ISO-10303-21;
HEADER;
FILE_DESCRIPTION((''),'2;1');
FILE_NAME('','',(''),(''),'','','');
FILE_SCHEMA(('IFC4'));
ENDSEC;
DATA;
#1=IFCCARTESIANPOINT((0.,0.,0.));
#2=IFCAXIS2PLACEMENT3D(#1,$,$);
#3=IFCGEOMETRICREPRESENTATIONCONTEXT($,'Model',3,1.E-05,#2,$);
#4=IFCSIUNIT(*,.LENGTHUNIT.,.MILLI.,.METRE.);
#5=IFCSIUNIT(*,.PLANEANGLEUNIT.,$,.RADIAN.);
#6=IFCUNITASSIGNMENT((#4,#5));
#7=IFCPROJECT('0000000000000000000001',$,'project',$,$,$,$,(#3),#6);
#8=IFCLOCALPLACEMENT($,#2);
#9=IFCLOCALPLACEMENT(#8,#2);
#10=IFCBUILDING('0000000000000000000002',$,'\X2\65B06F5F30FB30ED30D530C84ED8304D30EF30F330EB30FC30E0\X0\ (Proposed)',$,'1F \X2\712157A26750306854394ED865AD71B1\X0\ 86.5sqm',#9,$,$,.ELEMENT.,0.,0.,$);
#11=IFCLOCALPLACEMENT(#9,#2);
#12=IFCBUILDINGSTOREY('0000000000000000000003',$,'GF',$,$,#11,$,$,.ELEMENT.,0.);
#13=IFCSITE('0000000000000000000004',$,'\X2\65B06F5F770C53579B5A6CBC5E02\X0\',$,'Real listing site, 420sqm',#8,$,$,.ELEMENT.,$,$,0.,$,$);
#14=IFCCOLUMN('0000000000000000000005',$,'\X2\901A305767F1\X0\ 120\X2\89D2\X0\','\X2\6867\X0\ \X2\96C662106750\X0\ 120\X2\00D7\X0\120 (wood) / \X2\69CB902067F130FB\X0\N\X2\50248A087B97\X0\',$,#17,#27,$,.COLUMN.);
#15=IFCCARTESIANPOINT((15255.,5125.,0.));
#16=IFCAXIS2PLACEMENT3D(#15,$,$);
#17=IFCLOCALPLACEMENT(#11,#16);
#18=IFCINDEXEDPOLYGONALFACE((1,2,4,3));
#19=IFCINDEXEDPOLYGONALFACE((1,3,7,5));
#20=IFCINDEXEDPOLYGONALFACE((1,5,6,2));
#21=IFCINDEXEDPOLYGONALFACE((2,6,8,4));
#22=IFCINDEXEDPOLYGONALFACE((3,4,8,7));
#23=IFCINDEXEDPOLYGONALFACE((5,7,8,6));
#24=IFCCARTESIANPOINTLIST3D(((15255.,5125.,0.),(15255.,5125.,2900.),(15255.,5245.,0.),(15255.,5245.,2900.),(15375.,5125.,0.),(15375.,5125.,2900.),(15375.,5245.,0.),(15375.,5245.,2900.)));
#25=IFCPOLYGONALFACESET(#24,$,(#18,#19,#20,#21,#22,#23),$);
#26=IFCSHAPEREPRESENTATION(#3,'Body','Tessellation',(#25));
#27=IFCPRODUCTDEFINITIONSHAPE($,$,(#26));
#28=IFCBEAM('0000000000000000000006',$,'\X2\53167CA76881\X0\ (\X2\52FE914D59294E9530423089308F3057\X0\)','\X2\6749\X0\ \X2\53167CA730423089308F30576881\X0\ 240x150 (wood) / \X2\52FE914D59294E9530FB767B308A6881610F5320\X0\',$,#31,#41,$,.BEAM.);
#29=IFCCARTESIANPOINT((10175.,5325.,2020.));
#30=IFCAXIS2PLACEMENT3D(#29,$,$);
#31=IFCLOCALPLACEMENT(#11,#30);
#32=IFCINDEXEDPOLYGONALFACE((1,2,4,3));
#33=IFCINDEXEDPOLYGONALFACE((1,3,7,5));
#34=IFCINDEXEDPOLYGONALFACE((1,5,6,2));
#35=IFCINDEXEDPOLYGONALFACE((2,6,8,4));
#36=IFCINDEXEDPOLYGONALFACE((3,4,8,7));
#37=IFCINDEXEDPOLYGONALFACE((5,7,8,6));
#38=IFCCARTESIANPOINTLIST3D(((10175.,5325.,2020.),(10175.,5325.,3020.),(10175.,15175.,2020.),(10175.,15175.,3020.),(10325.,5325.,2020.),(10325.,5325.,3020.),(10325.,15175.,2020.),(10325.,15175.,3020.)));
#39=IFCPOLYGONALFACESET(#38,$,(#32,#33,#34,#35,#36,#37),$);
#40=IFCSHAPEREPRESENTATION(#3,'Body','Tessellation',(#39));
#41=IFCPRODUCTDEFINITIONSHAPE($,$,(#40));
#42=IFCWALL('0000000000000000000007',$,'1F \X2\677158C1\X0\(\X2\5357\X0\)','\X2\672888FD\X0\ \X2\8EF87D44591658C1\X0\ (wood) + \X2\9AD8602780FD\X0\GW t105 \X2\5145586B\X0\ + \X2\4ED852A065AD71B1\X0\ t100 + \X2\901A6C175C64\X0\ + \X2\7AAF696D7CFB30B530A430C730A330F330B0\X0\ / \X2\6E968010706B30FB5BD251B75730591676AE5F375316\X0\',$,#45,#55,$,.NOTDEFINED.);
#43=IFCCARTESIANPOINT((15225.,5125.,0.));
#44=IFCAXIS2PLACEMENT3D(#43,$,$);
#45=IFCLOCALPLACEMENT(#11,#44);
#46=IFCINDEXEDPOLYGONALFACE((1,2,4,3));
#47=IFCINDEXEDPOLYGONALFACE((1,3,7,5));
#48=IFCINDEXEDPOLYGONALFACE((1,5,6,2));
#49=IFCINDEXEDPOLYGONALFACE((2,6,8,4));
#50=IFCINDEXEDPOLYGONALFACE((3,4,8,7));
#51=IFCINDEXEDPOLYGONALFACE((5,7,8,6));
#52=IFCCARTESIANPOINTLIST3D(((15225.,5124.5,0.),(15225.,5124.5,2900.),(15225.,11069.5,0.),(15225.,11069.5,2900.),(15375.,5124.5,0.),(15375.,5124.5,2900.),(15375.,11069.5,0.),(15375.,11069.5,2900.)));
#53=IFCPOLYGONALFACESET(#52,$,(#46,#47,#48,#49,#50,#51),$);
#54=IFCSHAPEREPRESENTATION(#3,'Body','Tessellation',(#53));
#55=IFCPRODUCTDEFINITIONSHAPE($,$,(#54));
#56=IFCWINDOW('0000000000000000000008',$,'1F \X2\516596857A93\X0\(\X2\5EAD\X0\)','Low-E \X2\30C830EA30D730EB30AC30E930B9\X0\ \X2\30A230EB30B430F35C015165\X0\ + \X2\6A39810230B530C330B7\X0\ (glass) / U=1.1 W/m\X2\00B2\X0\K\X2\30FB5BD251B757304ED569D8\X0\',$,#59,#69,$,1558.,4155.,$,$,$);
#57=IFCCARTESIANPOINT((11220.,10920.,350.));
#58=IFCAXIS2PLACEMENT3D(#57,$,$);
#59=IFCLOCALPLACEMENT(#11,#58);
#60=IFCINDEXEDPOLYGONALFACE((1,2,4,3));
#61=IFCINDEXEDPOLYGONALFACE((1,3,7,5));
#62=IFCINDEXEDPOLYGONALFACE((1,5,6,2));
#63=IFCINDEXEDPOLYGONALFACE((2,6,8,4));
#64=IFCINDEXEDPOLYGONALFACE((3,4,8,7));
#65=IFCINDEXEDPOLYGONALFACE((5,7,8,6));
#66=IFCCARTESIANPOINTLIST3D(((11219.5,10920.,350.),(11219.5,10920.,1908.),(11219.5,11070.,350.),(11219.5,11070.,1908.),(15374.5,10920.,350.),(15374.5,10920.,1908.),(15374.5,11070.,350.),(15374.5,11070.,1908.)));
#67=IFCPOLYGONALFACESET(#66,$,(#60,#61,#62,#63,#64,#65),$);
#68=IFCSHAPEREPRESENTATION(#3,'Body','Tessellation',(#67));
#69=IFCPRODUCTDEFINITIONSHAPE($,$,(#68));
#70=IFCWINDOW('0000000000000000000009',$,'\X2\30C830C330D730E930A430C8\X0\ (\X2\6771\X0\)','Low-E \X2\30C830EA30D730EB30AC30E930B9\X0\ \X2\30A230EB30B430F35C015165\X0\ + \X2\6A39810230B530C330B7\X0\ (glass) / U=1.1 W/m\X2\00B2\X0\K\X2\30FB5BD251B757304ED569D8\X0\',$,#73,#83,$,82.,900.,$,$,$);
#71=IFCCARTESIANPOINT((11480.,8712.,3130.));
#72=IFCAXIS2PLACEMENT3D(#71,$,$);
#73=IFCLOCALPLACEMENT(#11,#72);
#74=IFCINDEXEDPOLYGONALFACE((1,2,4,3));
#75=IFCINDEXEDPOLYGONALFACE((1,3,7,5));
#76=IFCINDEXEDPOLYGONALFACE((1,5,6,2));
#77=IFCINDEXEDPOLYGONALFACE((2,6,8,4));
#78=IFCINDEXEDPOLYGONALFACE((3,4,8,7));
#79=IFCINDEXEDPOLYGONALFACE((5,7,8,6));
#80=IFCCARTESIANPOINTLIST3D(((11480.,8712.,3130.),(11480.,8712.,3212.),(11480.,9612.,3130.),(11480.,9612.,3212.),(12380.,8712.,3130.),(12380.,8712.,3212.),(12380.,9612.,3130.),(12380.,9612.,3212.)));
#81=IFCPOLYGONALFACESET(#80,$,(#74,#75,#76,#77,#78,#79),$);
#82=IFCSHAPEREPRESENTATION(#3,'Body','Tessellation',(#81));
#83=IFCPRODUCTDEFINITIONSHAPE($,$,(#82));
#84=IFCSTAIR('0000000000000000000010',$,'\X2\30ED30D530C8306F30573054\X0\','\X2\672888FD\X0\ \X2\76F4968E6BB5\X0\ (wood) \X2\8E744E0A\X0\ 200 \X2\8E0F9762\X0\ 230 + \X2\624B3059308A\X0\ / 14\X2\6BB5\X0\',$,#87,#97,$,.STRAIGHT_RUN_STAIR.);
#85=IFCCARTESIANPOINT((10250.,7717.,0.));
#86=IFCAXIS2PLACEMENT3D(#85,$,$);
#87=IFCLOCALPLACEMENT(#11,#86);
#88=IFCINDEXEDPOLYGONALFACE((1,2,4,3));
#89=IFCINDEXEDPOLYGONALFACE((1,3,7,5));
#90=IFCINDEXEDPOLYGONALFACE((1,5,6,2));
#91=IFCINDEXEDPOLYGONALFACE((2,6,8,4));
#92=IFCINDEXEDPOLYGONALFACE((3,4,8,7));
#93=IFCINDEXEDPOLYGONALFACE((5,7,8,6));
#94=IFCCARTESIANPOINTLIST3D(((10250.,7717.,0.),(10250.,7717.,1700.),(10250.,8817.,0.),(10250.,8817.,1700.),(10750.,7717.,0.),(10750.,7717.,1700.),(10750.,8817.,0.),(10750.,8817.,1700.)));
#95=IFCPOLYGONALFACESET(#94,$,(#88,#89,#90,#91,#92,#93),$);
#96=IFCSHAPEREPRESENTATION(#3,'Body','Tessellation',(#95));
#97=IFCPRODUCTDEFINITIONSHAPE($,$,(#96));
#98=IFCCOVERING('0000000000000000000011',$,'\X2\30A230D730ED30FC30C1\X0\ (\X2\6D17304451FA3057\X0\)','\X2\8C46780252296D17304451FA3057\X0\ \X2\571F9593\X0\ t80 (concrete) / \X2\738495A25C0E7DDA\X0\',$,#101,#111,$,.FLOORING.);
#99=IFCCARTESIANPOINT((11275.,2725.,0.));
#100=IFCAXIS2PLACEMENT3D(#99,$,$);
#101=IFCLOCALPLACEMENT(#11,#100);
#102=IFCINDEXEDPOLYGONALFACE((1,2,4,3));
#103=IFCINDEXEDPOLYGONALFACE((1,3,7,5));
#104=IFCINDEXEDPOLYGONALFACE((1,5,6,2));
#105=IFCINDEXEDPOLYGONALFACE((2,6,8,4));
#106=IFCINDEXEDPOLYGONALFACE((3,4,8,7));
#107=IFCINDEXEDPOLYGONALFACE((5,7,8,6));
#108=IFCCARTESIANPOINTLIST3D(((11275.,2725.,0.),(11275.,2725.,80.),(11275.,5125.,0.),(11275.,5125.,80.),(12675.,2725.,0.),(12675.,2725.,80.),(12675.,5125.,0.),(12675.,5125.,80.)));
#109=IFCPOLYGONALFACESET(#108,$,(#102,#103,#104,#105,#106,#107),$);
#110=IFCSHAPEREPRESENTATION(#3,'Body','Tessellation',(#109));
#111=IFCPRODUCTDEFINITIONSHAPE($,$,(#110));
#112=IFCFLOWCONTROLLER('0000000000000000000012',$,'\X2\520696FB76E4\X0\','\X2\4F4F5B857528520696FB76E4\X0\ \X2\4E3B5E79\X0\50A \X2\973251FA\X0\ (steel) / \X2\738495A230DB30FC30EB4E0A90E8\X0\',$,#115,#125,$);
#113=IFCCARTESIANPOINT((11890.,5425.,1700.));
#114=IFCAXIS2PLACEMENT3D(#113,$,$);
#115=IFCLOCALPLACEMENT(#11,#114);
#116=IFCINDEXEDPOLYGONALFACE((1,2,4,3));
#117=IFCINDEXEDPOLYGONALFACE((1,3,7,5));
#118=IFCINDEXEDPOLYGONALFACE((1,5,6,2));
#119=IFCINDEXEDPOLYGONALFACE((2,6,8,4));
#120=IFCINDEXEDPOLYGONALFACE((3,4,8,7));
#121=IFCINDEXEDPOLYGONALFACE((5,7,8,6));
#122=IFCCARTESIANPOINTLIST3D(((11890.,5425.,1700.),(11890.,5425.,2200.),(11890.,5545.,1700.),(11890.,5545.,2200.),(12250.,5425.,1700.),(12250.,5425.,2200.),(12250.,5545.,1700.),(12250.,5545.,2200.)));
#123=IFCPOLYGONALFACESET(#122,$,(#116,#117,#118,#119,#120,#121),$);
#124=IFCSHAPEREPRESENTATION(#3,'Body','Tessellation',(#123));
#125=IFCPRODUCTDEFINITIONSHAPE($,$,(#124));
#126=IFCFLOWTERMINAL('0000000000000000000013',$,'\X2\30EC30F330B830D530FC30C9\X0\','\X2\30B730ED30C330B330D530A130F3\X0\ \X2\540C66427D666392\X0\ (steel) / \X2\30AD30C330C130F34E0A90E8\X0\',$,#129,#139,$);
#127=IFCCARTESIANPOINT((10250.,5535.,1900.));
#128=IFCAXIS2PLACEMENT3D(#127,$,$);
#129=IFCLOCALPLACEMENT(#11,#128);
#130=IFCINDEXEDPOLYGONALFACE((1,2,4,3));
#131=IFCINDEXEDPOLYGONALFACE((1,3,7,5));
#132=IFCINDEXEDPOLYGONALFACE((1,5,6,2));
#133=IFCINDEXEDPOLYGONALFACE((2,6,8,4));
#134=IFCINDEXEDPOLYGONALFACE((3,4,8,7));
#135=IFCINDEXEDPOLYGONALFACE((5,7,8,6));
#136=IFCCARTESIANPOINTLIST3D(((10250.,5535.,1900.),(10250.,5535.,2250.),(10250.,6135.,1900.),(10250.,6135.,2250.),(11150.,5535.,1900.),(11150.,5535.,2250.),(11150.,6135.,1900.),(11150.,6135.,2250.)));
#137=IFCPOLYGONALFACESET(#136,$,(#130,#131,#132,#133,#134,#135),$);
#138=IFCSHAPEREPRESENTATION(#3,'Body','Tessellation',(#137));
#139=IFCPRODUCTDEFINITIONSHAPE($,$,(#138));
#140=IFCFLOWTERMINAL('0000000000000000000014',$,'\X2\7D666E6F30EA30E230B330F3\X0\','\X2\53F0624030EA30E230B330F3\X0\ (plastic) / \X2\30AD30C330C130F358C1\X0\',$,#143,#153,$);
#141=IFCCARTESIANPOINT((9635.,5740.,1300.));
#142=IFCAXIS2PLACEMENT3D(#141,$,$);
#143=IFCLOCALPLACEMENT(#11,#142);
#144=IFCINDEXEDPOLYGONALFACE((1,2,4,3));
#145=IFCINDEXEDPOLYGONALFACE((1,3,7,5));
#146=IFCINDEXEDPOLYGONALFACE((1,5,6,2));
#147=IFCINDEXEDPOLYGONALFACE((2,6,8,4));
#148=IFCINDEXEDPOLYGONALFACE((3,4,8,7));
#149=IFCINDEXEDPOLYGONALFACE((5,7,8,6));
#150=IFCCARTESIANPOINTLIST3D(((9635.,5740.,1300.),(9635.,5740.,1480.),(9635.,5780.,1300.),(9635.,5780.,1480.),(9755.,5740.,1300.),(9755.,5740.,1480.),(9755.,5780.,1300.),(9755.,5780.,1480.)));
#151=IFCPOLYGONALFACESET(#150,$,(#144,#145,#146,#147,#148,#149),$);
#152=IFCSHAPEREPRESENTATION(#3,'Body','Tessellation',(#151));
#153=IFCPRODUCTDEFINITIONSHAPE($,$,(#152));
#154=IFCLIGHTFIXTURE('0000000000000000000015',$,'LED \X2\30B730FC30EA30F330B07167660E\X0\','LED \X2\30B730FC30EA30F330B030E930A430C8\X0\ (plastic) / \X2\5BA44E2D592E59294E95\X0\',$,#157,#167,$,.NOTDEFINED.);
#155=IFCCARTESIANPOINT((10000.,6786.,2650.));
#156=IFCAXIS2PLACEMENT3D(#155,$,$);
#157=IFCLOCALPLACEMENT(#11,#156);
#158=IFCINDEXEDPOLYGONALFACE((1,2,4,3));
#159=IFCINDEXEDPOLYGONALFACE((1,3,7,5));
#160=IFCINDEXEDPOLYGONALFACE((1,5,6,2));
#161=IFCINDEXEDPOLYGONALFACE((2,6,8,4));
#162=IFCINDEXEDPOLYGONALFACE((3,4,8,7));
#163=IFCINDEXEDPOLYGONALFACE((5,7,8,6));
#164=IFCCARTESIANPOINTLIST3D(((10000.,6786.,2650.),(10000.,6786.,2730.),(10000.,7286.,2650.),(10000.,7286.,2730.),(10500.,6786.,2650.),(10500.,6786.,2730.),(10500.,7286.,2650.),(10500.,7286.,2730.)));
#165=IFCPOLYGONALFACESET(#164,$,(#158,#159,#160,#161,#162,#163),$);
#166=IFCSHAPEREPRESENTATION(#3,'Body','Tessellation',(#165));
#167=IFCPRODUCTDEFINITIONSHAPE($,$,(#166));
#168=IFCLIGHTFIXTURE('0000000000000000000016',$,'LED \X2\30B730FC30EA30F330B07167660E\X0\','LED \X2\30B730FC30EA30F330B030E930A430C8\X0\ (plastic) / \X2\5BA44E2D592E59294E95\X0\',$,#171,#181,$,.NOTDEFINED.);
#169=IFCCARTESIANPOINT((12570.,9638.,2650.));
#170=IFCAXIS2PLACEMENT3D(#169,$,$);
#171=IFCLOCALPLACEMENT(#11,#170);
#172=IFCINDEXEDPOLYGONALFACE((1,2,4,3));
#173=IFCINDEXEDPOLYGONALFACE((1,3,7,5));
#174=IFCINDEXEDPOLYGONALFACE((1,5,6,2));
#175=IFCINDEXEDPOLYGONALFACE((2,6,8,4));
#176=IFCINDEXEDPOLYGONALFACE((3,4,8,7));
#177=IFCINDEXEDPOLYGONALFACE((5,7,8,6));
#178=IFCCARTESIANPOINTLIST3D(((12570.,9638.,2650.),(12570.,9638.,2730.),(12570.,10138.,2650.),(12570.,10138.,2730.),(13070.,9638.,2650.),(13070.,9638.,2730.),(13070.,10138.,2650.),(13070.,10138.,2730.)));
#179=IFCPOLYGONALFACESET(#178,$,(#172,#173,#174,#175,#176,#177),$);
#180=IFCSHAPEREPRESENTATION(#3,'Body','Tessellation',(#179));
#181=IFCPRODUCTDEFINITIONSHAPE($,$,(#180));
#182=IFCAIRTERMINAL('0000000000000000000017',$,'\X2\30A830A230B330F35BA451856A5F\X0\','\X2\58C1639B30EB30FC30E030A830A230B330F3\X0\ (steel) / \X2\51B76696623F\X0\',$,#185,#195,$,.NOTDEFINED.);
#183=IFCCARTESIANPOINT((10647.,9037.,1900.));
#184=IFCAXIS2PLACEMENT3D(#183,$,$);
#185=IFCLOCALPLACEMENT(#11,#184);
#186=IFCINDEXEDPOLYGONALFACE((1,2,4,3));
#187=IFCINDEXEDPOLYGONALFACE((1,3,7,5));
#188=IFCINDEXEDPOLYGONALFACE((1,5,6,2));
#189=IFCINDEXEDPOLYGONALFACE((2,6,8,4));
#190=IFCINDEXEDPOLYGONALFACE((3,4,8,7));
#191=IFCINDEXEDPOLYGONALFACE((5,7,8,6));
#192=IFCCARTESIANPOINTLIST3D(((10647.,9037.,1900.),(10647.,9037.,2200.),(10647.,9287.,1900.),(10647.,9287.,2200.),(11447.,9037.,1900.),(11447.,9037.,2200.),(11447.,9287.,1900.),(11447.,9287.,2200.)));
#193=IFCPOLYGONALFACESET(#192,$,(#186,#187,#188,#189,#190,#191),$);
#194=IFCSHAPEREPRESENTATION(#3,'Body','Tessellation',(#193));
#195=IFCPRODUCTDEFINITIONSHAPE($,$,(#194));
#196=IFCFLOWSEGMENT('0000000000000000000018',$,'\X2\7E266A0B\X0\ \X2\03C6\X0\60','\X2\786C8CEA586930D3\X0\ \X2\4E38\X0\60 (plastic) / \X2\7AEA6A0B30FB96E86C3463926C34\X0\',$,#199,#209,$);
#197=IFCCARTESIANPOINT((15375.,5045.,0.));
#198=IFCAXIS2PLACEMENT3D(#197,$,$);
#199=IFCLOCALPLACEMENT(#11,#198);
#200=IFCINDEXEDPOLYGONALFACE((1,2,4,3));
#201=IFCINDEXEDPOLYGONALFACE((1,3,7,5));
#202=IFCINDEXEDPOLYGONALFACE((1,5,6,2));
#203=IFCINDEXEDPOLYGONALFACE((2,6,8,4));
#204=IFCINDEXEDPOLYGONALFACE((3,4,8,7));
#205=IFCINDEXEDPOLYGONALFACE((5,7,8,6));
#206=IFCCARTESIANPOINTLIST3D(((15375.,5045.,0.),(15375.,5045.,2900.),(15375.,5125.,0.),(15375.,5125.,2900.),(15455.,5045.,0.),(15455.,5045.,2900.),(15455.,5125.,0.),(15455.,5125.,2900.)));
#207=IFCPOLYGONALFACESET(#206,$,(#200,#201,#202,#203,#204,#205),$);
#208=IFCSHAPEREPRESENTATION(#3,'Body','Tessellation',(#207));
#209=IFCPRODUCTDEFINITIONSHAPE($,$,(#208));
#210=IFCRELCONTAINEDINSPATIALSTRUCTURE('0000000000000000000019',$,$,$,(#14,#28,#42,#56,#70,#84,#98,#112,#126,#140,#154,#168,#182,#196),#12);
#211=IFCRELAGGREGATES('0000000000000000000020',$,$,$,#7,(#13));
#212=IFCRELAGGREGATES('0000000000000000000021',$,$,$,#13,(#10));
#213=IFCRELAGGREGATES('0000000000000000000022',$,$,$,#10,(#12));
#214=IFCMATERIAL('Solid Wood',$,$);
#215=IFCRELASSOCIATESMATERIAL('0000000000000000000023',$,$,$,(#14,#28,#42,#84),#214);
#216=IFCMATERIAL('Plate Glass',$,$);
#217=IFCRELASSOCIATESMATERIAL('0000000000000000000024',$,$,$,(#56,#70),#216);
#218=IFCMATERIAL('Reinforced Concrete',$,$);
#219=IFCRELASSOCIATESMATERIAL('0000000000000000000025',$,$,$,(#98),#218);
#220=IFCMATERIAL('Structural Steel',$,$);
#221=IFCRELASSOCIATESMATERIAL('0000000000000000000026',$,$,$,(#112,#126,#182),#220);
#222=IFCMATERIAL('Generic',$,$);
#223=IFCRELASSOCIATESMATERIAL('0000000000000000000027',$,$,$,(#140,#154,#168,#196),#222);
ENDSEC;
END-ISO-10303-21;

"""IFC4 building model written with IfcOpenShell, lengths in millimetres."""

from ifc_helpers import new_model, si_unit, frame, frame_2d, origin, place, context, project, spatial, rectangle, extrude, material, element, fill, save


model = new_model("IFC4")

# Units and contexts
model_context = context("Model", 3, precision=1e-05, world=origin())
ifc_project = project(units=[si_unit("LENGTHUNIT", "METRE", prefix="MILLI"), si_unit("PLANEANGLEUNIT", "RADIAN")], contexts=[model_context])

# Site, building, storey
site_placement = place(None, origin())
site = spatial("IfcSite", under=ifc_project, at=site_placement, Name="新潟県南魚沼市", ObjectType="Real listing site, 420sqm", CompositionType="ELEMENT", RefElevation=0.0)
building_placement = place(site_placement, origin())
building = spatial("IfcBuilding", under=site, at=building_placement, Name="新潟・ロフト付きワンルーム (Proposed)", ObjectType="1F 無垢材と吹付断熱 86.5sqm", CompositionType="ELEMENT", ElevationOfRefHeight=0.0, ElevationOfTerrain=0.0)
storey_placement = place(building_placement, origin())
storey = spatial("IfcBuildingStorey", under=building, at=storey_placement, Name="GF", CompositionType="ELEMENT", Elevation=0.0)

# Column
ifc_material_1 = material(Name="Solid Wood")
column_1_placement = place(storey_placement, frame((15255.0, 5125.0, 0.0)))
element("IfcColumn", 1, at=column_1_placement, inside=storey, material=ifc_material_1, Name="通し柱 120角", Description="桧 集成材 120×120 (wood) / 構造柱・N値計算", PredefinedType="COLUMN", context=model_context, shape_type="SweptSolid", body=[
    extrude(rectangle(XDim=120.0, YDim=120.0, at=frame_2d((60.0, 60.0))), frame((15255.0, 5125.0, 0.0)), (0.0, 0.0, 1.0), 2900.0),
])

# Beam
beam_1_placement = place(storey_placement, frame((10175.0, 5325.0, 2020.0)))
element("IfcBeam", 2, at=beam_1_placement, inside=storey, material=ifc_material_1, Name="化粧梁 (勾配天井あらわし)", Description="杉 化粧あらわし梁 240x150 (wood) / 勾配天井・登り梁意匠", PredefinedType="BEAM", context=model_context, shape_type="SweptSolid", body=[
    extrude(rectangle(XDim=150.0, YDim=9850.0, at=frame_2d((75.0, 4925.0))), frame((10175.0, 5325.0, 2020.0)), (0.0, 0.0, 1.0), 1000.0),
])

# Wall, opening, window
wall_1_placement = place(storey_placement, frame((15225.0, 5125.0, 0.0)))
wall_1 = element("IfcWall", 3, at=wall_1_placement, inside=storey, material=ifc_material_1, Name="1F 東壁(南)", Description="木製 軸組外壁 (wood) + 高性能GW t105 充填 + 付加断熱 t100 + 通気層 + 窯業系サイディング / 準耐火・寒冷地外皮強化", PredefinedType="NOTDEFINED", context=model_context, shape_type="SweptSolid", body=[
    extrude(rectangle(XDim=150.0, YDim=5945.0, at=frame_2d((75.0, 2972.0))), frame((15225.0, 5125.0, 0.0)), (0.0, 0.0, 1.0), 2900.0),
])
opening_placement = place(storey_placement, frame((11220.0, 10920.0, 350.0)))
opening = element("IfcOpeningElement", 4, at=opening_placement, cuts=wall_1, PredefinedType="NOTDEFINED", context=model_context, shape_type="SweptSolid", body=[
    extrude(rectangle(XDim=4155.0, YDim=150.0, at=frame_2d((2077.0, 75.0))), frame((11220.0, 10920.0, 350.0)), (0.0, 0.0, 1.0), 1558.0),
])
ifc_material_2 = material(Name="Plate Glass")
window_1_placement = place(storey_placement, frame((11220.0, 10920.0, 350.0)))
window_1 = element("IfcWindow", 5, at=window_1_placement, inside=storey, material=ifc_material_2, Name="1F 入隅窓(庭)", Description="Low-E トリプルガラス アルゴン封入 + 樹脂サッシ (glass) / U=1.1 W/m²K・寒冷地仕様", OverallHeight=1558.0, OverallWidth=4155.0, context=model_context, shape_type="SweptSolid", body=[
    extrude(rectangle(XDim=4155.0, YDim=150.0, at=frame_2d((2077.0, 75.0))), frame((11220.0, 10920.0, 350.0)), (0.0, 0.0, 1.0), 1558.0),
])
fill(opening, window_1)

# Window
window_2_placement = place(storey_placement, frame((11480.0, 8712.0, 3130.0)))
element("IfcWindow", 6, at=window_2_placement, inside=storey, material=ifc_material_2, Name="トップライト (東)", Description="Low-E トリプルガラス アルゴン封入 + 樹脂サッシ (glass) / U=1.1 W/m²K・寒冷地仕様", OverallHeight=82.0, OverallWidth=900.0, context=model_context, shape_type="SweptSolid", body=[
    extrude(rectangle(XDim=900.0, YDim=900.0, at=frame_2d((450.0, 450.0))), frame((11480.0, 8712.0, 3130.0)), (0.0, 0.0, 1.0), 82.0),
])

# Stair
stair_placement = place(storey_placement, frame((10250.0, 7717.0, 0.0)))
element("IfcStair", 7, at=stair_placement, inside=storey, material=ifc_material_1, Name="ロフトはしご", Description="木製 直階段 (wood) 蹴上 200 踏面 230 + 手すり / 14段", PredefinedType="STRAIGHT_RUN_STAIR", context=model_context, shape_type="SweptSolid", body=[
    extrude(rectangle(XDim=500.0, YDim=1100.0, at=frame_2d((250.0, 550.0))), frame((10250.0, 7717.0, 0.0)), (0.0, 0.0, 1.0), 1700.0),
])

# Covering
ifc_material_3 = material(Name="Reinforced Concrete")
covering_placement = place(storey_placement, frame((11275.0, 2725.0, 0.0)))
element("IfcCovering", 8, at=covering_placement, inside=storey, material=ifc_material_3, Name="アプローチ (洗い出し)", Description="豆砂利洗い出し 土間 t80 (concrete) / 玄関導線", PredefinedType="FLOORING", context=model_context, shape_type="SweptSolid", body=[
    extrude(rectangle(XDim=1400.0, YDim=2400.0, at=frame_2d((700.0, 1200.0))), frame((11275.0, 2725.0, 0.0)), (0.0, 0.0, 1.0), 80.0),
])

# Flow controller
ifc_material_4 = material(Name="Structural Steel")
flow_controller_placement = place(storey_placement, frame((11890.0, 5425.0, 1700.0)))
element("IfcFlowController", 9, at=flow_controller_placement, inside=storey, material=ifc_material_4, Name="分電盤", Description="住宅用分電盤 主幹50A 露出 (steel) / 玄関ホール上部", context=model_context, shape_type="SweptSolid", body=[
    extrude(rectangle(XDim=360.0, YDim=120.0, at=frame_2d((180.0, 60.0))), frame((11890.0, 5425.0, 1700.0)), (0.0, 0.0, 1.0), 500.0),
])

# Flow terminals
flow_terminal_1_placement = place(storey_placement, frame((10250.0, 5535.0, 1900.0)))
element("IfcFlowTerminal", 10, at=flow_terminal_1_placement, inside=storey, material=ifc_material_4, Name="レンジフード", Description="シロッコファン 同時給排 (steel) / キッチン上部", context=model_context, shape_type="SweptSolid", body=[
    extrude(rectangle(XDim=900.0, YDim=600.0, at=frame_2d((450.0, 300.0))), frame((10250.0, 5535.0, 1900.0)), (0.0, 0.0, 1.0), 350.0),
])
ifc_material_5 = material(Name="Generic")
flow_terminal_2_placement = place(storey_placement, frame((9635.0, 5740.0, 1300.0)))
element("IfcFlowTerminal", 11, at=flow_terminal_2_placement, inside=storey, material=ifc_material_5, Name="給湯リモコン", Description="台所リモコン (plastic) / キッチン壁", context=model_context, shape_type="SweptSolid", body=[
    extrude(rectangle(XDim=120.0, YDim=40.0, at=frame_2d((60.0, 20.0))), frame((9635.0, 5740.0, 1300.0)), (0.0, 0.0, 1.0), 180.0),
])

# Light fixtures
light_fixture_1_placement = place(storey_placement, frame((10000.0, 6786.0, 2650.0)))
element("IfcLightFixture", 12, at=light_fixture_1_placement, inside=storey, material=ifc_material_5, Name="LED シーリング照明", Description="LED シーリングライト (plastic) / 室中央天井", PredefinedType="NOTDEFINED", context=model_context, shape_type="SweptSolid", body=[
    extrude(rectangle(XDim=500.0, YDim=500.0, at=frame_2d((250.0, 250.0))), frame((10000.0, 6786.0, 2650.0)), (0.0, 0.0, 1.0), 80.0),
])
light_fixture_2_placement = place(storey_placement, frame((12570.0, 9638.0, 2650.0)))
element("IfcLightFixture", 13, at=light_fixture_2_placement, inside=storey, material=ifc_material_5, Name="LED シーリング照明", Description="LED シーリングライト (plastic) / 室中央天井", PredefinedType="NOTDEFINED", context=model_context, shape_type="SweptSolid", body=[
    extrude(rectangle(XDim=500.0, YDim=500.0, at=frame_2d((250.0, 250.0))), frame((12570.0, 9638.0, 2650.0)), (0.0, 0.0, 1.0), 80.0),
])

# Air terminal
air_terminal_placement = place(storey_placement, frame((10647.0, 9037.0, 1900.0)))
element("IfcAirTerminal", 14, at=air_terminal_placement, inside=storey, material=ifc_material_4, Name="エアコン室内機", Description="壁掛ルームエアコン (steel) / 冷暖房", PredefinedType="NOTDEFINED", context=model_context, shape_type="SweptSolid", body=[
    extrude(rectangle(XDim=800.0, YDim=250.0, at=frame_2d((400.0, 125.0))), frame((10647.0, 9037.0, 1900.0)), (0.0, 0.0, 1.0), 300.0),
])

# Flow segment
flow_segment_placement = place(storey_placement, frame((15375.0, 5045.0, 0.0)))
element("IfcFlowSegment", 15, at=flow_segment_placement, inside=storey, material=ifc_material_5, Name="縦樋 φ60", Description="硬質塩ビ 丸60 (plastic) / 竪樋・雨水排水", context=model_context, shape_type="SweptSolid", body=[
    extrude(rectangle(XDim=80.0, YDim=80.0, at=frame_2d((40.0, 40.0))), frame((15375.0, 5045.0, 0.0)), (0.0, 0.0, 1.0), 2900.0),
])

save(model, "model.ifc")
